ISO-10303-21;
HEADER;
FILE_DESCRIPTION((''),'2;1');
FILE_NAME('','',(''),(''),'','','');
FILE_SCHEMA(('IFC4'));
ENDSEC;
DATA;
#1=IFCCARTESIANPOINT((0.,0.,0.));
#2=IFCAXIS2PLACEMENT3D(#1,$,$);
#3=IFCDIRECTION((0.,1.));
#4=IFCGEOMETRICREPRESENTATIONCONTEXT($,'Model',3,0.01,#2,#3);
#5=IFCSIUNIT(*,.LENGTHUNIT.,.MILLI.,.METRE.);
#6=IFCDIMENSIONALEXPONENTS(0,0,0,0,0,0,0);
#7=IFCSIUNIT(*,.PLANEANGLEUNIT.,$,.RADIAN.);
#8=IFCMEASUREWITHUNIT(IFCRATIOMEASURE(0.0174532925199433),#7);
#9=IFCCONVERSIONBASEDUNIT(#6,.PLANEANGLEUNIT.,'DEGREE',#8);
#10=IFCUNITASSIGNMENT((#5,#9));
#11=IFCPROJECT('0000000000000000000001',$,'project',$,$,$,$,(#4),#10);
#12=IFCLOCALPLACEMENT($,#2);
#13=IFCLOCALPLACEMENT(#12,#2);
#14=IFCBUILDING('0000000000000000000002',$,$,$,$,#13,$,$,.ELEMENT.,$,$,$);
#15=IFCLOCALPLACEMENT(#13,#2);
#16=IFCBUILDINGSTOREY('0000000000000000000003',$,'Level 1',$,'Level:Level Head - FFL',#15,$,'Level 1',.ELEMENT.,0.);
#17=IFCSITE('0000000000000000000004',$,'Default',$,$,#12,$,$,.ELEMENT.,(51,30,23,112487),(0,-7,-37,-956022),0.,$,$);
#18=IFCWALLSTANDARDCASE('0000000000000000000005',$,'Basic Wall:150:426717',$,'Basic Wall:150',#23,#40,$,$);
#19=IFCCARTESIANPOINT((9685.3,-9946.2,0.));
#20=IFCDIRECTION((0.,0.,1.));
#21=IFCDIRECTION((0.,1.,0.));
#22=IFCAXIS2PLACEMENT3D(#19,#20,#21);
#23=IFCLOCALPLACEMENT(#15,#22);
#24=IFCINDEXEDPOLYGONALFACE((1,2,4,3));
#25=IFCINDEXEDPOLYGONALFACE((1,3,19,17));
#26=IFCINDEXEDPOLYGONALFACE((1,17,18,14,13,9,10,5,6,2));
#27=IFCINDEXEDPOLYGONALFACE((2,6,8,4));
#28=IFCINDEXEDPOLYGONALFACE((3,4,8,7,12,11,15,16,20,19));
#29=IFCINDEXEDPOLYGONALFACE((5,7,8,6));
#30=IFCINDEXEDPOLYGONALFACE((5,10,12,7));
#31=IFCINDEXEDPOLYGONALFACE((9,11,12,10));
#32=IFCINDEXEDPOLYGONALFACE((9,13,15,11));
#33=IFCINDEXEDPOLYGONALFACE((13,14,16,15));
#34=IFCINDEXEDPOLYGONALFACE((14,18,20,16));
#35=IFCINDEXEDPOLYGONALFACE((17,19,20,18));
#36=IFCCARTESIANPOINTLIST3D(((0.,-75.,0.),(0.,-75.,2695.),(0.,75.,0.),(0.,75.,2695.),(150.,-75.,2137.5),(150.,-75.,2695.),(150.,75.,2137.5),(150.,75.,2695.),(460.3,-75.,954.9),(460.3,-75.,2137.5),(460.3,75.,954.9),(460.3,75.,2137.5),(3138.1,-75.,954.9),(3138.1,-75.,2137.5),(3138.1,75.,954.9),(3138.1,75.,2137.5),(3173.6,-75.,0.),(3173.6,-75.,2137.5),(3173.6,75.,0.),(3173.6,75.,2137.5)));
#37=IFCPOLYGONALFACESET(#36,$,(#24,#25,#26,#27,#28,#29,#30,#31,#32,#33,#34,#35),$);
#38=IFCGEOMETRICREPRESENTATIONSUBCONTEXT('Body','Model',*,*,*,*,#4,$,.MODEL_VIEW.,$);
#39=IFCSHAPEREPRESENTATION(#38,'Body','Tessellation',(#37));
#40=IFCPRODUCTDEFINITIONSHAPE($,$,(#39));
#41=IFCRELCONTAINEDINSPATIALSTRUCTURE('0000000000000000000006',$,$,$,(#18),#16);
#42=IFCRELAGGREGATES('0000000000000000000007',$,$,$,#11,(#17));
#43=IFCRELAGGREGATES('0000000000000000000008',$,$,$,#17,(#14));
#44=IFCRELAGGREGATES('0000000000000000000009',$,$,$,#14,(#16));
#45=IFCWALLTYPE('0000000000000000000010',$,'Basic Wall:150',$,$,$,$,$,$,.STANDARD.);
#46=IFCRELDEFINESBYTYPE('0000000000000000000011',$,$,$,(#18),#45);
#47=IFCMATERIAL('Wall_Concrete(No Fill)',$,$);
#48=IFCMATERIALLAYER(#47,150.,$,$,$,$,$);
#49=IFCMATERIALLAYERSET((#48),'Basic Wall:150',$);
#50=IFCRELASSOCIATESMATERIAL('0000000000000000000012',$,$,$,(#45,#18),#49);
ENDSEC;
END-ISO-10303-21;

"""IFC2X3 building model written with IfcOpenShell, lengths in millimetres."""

from ifc_helpers import new_model, entity, si_unit, converted_unit, direction, frame, frame_2d, origin, place, context, subcontext, project, spatial, rectangle, extrude, material, layer, layer_set, layer_usage, type_object, element, save


model = new_model("IFC2X3")

# Units and contexts
model_context = context("Model", 3, precision=0.01, world=origin(), true_north=direction((0.0, 1.0)))
body_context = subcontext(model_context, "Body", "Model", "MODEL_VIEW")
ifc_project = project(units=[si_unit("LENGTHUNIT", "METRE", prefix="MILLI"), converted_unit("PLANEANGLEUNIT", "DEGREE", entity("IfcRatioMeasure", 0.0174532925199433), si_unit("PLANEANGLEUNIT", "RADIAN"), dimensions=[0, 0, 0, 0, 0, 0, 0])], contexts=[model_context])

# Site, building, storey
site_placement = place(None, origin())
site = spatial("IfcSite", under=ifc_project, at=site_placement, Name="Default", CompositionType="ELEMENT", RefLatitude=(51, 30, 23, 112487), RefLongitude=(0, -7, -37, -956022), RefElevation=0.0)
building_placement = place(site_placement, origin())
building = spatial("IfcBuilding", under=site, at=building_placement, CompositionType="ELEMENT")
storey_placement = place(building_placement, origin())
storey = spatial("IfcBuildingStorey", under=building, at=storey_placement, Name="Level 1", ObjectType="Level:Level Head - FFL", LongName="Level 1", CompositionType="ELEMENT", Elevation=0.0)

# Shared definitions
ifc_material_1 = material(Name="Wall_Concrete(No Fill)")

# Wall, openings
ifc_layer_1 = layer(ifc_material_1, 150.0)
ifc_layer_set_1 = layer_set([ifc_layer_1], Name="Basic Wall:150")
ifc_layer_usage_1 = layer_usage(ifc_layer_set_1, "AXIS2", "NEGATIVE", 75.0)
wall_type_1 = type_object("IfcWallType", Name="Basic Wall:150", PredefinedType="STANDARD", material=ifc_layer_set_1)
wall_1_placement = place(storey_placement, frame((9685.3, -9946.2, 0.0), z_axis=(0.0, 0.0, 1.0), x_axis=(0.0, 1.0, 0.0)))
wall_1 = element("IfcWallStandardCase", 1, at=wall_1_placement, inside=storey, type_object=wall_type_1, material=ifc_layer_usage_1, Name="Basic Wall:150:426717", ObjectType="Basic Wall:150", context=body_context, shape_type="SweptSolid", body=[
    extrude(rectangle(XDim=3173.6, YDim=150.0, at=frame_2d((1586.8, 0.0), x_axis=(-1.0, 0.0))), origin(), (0.0, 0.0, 1.0), 2695.0),
])
opening_1_placement = place(wall_1_placement, origin())
element("IfcOpeningElement", 2, at=opening_1_placement, cuts=wall_1, ObjectType="Opening", context=body_context, shape_type="SweptSolid", body=[
    extrude(rectangle(XDim=757.5, YDim=3023.6, at=frame_2d((0.0, 0.0), x_axis=(1.0, 0.0))), frame((1661.8, -75.0, 2516.3), z_axis=(0.0, 1.0, 0.0), x_axis=(0.0, 0.0, -1.0)), (0.0, 0.0, 1.0), 150.0),
])
opening_2_placement = place(wall_1_placement, origin())
element("IfcOpeningElement", 3, at=opening_2_placement, cuts=wall_1, ObjectType="Opening", context=body_context, shape_type="SweptSolid", body=[
    extrude(rectangle(XDim=1928.4, YDim=2677.8, at=frame_2d((0.0, 0.0), x_axis=(1.0, 0.0))), frame((1799.2, -75.0, 1919.1), z_axis=(0.0, 1.0, 0.0), x_axis=(0.0, 0.0, -1.0)), (0.0, 0.0, 1.0), 150.0),
])

save(model, "model.ifc")
